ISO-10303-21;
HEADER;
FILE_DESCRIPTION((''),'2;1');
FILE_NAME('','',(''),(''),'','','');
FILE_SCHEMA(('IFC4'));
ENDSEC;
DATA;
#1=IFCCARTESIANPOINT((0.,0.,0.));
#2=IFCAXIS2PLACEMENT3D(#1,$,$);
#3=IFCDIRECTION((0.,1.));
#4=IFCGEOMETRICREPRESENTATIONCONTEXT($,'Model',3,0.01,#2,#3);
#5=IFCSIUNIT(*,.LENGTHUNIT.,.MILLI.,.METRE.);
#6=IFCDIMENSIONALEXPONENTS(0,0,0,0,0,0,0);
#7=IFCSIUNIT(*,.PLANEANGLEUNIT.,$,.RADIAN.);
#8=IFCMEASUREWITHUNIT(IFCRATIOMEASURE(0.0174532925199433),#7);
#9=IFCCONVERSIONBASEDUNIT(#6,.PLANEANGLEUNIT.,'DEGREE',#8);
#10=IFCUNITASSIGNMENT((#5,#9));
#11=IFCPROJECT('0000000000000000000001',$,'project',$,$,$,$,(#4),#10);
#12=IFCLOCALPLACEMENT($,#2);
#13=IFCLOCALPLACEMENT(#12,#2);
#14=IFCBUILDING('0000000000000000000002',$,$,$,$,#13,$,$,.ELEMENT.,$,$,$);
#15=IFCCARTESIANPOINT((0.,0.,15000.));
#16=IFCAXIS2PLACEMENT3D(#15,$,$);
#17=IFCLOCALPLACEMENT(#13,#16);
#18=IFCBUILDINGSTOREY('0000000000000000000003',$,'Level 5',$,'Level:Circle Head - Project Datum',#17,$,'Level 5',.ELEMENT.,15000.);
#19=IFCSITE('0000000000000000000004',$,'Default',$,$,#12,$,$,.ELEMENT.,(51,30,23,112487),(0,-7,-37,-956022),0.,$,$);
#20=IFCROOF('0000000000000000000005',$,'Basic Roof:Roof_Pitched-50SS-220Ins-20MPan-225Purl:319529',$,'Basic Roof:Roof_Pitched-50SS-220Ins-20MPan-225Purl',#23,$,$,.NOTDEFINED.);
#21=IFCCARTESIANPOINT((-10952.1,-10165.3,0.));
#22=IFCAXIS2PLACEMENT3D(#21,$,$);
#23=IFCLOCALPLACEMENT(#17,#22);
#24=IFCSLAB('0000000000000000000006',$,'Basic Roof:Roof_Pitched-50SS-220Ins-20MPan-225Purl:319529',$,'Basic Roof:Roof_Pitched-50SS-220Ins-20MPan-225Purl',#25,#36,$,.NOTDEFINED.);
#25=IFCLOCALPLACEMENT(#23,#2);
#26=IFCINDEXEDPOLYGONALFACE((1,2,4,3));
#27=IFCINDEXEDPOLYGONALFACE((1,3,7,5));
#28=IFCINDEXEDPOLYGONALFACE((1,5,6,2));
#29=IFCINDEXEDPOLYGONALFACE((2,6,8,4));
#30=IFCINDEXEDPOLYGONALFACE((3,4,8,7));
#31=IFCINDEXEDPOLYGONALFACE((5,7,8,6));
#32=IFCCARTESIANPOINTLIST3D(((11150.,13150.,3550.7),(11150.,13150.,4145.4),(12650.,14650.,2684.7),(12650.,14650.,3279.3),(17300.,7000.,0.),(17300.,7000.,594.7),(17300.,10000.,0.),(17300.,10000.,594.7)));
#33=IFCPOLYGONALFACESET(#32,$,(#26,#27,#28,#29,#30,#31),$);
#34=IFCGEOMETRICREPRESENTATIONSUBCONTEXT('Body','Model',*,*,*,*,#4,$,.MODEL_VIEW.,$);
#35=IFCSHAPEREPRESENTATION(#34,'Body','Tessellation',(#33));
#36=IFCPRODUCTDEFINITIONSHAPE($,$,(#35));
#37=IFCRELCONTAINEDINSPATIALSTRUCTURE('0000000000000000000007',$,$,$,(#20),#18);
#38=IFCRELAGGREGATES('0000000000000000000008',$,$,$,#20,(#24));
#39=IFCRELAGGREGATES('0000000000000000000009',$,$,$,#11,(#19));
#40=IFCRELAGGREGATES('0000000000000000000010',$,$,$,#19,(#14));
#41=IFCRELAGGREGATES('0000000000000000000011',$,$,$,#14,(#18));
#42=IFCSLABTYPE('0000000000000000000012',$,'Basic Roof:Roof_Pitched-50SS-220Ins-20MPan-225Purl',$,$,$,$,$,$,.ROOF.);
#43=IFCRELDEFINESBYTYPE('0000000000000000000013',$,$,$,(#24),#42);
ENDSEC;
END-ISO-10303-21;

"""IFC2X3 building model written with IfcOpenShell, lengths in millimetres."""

from ifc_helpers import new_model, entity, si_unit, converted_unit, direction, frame, origin, place, context, subcontext, project, spatial, polyline, outline, extrude, type_object, element, aggregate, save


model = new_model("IFC2X3")

# Units and contexts
model_context = context("Model", 3, precision=0.01, world=origin(), true_north=direction((0.0, 1.0)))
body_context = subcontext(model_context, "Body", "Model", "MODEL_VIEW")
ifc_project = project(units=[si_unit("LENGTHUNIT", "METRE", prefix="MILLI"), converted_unit("PLANEANGLEUNIT", "DEGREE", entity("IfcRatioMeasure", 0.0174532925199433), si_unit("PLANEANGLEUNIT", "RADIAN"), dimensions=[0, 0, 0, 0, 0, 0, 0])], contexts=[model_context])

# Site, building, storey
site_placement = place(None, origin())
site = spatial("IfcSite", under=ifc_project, at=site_placement, Name="Default", CompositionType="ELEMENT", RefLatitude=(51, 30, 23, 112487), RefLongitude=(0, -7, -37, -956022), RefElevation=0.0)
building_placement = place(site_placement, origin())
building = spatial("IfcBuilding", under=site, at=building_placement, CompositionType="ELEMENT")
storey_placement = place(building_placement, frame((0.0, 0.0, 15000.0)))
storey = spatial("IfcBuildingStorey", under=building, at=storey_placement, Name="Level 5", ObjectType="Level:Circle Head - Project Datum", LongName="Level 5", CompositionType="ELEMENT", Elevation=15000.0)

# Roof, slab
roof_placement = place(storey_placement, frame((-10952.1, -10165.3, 0.0)))
roof = element("IfcRoof", 1, at=roof_placement, inside=storey, Name="Basic Roof:Roof_Pitched-50SS-220Ins-20MPan-225Purl:319529", ObjectType="Basic Roof:Roof_Pitched-50SS-220Ins-20MPan-225Purl", ShapeType="NOTDEFINED")
slab_type_1 = type_object("IfcSlabType", Name="Basic Roof:Roof_Pitched-50SS-220Ins-20MPan-225Purl", PredefinedType="ROOF")
slab_1_placement = place(roof_placement, origin())
slab_1 = element("IfcSlab", 2, at=slab_1_placement, type_object=slab_type_1, Name="Basic Roof:Roof_Pitched-50SS-220Ins-20MPan-225Purl:319529", ObjectType="Basic Roof:Roof_Pitched-50SS-220Ins-20MPan-225Purl", PredefinedType="NOTDEFINED", context=body_context, shape_type="SweptSolid", body=[
    extrude(outline(polyline([(3550.7, -3825.0), (3550.7, -825.0), (-1818.7, 3825.0), (-3550.7, 2325.0), (3550.7, -3825.0)])), frame((14225.0, 10825.0, 1775.4), z_axis=(0.5, 0.0, 0.866025), x_axis=(0.866025, 0.0, -0.5)), (-0.5, 0.0, 0.866025), 594.7),
])
aggregate(roof, [slab_1])

save(model, "model.ifc")
